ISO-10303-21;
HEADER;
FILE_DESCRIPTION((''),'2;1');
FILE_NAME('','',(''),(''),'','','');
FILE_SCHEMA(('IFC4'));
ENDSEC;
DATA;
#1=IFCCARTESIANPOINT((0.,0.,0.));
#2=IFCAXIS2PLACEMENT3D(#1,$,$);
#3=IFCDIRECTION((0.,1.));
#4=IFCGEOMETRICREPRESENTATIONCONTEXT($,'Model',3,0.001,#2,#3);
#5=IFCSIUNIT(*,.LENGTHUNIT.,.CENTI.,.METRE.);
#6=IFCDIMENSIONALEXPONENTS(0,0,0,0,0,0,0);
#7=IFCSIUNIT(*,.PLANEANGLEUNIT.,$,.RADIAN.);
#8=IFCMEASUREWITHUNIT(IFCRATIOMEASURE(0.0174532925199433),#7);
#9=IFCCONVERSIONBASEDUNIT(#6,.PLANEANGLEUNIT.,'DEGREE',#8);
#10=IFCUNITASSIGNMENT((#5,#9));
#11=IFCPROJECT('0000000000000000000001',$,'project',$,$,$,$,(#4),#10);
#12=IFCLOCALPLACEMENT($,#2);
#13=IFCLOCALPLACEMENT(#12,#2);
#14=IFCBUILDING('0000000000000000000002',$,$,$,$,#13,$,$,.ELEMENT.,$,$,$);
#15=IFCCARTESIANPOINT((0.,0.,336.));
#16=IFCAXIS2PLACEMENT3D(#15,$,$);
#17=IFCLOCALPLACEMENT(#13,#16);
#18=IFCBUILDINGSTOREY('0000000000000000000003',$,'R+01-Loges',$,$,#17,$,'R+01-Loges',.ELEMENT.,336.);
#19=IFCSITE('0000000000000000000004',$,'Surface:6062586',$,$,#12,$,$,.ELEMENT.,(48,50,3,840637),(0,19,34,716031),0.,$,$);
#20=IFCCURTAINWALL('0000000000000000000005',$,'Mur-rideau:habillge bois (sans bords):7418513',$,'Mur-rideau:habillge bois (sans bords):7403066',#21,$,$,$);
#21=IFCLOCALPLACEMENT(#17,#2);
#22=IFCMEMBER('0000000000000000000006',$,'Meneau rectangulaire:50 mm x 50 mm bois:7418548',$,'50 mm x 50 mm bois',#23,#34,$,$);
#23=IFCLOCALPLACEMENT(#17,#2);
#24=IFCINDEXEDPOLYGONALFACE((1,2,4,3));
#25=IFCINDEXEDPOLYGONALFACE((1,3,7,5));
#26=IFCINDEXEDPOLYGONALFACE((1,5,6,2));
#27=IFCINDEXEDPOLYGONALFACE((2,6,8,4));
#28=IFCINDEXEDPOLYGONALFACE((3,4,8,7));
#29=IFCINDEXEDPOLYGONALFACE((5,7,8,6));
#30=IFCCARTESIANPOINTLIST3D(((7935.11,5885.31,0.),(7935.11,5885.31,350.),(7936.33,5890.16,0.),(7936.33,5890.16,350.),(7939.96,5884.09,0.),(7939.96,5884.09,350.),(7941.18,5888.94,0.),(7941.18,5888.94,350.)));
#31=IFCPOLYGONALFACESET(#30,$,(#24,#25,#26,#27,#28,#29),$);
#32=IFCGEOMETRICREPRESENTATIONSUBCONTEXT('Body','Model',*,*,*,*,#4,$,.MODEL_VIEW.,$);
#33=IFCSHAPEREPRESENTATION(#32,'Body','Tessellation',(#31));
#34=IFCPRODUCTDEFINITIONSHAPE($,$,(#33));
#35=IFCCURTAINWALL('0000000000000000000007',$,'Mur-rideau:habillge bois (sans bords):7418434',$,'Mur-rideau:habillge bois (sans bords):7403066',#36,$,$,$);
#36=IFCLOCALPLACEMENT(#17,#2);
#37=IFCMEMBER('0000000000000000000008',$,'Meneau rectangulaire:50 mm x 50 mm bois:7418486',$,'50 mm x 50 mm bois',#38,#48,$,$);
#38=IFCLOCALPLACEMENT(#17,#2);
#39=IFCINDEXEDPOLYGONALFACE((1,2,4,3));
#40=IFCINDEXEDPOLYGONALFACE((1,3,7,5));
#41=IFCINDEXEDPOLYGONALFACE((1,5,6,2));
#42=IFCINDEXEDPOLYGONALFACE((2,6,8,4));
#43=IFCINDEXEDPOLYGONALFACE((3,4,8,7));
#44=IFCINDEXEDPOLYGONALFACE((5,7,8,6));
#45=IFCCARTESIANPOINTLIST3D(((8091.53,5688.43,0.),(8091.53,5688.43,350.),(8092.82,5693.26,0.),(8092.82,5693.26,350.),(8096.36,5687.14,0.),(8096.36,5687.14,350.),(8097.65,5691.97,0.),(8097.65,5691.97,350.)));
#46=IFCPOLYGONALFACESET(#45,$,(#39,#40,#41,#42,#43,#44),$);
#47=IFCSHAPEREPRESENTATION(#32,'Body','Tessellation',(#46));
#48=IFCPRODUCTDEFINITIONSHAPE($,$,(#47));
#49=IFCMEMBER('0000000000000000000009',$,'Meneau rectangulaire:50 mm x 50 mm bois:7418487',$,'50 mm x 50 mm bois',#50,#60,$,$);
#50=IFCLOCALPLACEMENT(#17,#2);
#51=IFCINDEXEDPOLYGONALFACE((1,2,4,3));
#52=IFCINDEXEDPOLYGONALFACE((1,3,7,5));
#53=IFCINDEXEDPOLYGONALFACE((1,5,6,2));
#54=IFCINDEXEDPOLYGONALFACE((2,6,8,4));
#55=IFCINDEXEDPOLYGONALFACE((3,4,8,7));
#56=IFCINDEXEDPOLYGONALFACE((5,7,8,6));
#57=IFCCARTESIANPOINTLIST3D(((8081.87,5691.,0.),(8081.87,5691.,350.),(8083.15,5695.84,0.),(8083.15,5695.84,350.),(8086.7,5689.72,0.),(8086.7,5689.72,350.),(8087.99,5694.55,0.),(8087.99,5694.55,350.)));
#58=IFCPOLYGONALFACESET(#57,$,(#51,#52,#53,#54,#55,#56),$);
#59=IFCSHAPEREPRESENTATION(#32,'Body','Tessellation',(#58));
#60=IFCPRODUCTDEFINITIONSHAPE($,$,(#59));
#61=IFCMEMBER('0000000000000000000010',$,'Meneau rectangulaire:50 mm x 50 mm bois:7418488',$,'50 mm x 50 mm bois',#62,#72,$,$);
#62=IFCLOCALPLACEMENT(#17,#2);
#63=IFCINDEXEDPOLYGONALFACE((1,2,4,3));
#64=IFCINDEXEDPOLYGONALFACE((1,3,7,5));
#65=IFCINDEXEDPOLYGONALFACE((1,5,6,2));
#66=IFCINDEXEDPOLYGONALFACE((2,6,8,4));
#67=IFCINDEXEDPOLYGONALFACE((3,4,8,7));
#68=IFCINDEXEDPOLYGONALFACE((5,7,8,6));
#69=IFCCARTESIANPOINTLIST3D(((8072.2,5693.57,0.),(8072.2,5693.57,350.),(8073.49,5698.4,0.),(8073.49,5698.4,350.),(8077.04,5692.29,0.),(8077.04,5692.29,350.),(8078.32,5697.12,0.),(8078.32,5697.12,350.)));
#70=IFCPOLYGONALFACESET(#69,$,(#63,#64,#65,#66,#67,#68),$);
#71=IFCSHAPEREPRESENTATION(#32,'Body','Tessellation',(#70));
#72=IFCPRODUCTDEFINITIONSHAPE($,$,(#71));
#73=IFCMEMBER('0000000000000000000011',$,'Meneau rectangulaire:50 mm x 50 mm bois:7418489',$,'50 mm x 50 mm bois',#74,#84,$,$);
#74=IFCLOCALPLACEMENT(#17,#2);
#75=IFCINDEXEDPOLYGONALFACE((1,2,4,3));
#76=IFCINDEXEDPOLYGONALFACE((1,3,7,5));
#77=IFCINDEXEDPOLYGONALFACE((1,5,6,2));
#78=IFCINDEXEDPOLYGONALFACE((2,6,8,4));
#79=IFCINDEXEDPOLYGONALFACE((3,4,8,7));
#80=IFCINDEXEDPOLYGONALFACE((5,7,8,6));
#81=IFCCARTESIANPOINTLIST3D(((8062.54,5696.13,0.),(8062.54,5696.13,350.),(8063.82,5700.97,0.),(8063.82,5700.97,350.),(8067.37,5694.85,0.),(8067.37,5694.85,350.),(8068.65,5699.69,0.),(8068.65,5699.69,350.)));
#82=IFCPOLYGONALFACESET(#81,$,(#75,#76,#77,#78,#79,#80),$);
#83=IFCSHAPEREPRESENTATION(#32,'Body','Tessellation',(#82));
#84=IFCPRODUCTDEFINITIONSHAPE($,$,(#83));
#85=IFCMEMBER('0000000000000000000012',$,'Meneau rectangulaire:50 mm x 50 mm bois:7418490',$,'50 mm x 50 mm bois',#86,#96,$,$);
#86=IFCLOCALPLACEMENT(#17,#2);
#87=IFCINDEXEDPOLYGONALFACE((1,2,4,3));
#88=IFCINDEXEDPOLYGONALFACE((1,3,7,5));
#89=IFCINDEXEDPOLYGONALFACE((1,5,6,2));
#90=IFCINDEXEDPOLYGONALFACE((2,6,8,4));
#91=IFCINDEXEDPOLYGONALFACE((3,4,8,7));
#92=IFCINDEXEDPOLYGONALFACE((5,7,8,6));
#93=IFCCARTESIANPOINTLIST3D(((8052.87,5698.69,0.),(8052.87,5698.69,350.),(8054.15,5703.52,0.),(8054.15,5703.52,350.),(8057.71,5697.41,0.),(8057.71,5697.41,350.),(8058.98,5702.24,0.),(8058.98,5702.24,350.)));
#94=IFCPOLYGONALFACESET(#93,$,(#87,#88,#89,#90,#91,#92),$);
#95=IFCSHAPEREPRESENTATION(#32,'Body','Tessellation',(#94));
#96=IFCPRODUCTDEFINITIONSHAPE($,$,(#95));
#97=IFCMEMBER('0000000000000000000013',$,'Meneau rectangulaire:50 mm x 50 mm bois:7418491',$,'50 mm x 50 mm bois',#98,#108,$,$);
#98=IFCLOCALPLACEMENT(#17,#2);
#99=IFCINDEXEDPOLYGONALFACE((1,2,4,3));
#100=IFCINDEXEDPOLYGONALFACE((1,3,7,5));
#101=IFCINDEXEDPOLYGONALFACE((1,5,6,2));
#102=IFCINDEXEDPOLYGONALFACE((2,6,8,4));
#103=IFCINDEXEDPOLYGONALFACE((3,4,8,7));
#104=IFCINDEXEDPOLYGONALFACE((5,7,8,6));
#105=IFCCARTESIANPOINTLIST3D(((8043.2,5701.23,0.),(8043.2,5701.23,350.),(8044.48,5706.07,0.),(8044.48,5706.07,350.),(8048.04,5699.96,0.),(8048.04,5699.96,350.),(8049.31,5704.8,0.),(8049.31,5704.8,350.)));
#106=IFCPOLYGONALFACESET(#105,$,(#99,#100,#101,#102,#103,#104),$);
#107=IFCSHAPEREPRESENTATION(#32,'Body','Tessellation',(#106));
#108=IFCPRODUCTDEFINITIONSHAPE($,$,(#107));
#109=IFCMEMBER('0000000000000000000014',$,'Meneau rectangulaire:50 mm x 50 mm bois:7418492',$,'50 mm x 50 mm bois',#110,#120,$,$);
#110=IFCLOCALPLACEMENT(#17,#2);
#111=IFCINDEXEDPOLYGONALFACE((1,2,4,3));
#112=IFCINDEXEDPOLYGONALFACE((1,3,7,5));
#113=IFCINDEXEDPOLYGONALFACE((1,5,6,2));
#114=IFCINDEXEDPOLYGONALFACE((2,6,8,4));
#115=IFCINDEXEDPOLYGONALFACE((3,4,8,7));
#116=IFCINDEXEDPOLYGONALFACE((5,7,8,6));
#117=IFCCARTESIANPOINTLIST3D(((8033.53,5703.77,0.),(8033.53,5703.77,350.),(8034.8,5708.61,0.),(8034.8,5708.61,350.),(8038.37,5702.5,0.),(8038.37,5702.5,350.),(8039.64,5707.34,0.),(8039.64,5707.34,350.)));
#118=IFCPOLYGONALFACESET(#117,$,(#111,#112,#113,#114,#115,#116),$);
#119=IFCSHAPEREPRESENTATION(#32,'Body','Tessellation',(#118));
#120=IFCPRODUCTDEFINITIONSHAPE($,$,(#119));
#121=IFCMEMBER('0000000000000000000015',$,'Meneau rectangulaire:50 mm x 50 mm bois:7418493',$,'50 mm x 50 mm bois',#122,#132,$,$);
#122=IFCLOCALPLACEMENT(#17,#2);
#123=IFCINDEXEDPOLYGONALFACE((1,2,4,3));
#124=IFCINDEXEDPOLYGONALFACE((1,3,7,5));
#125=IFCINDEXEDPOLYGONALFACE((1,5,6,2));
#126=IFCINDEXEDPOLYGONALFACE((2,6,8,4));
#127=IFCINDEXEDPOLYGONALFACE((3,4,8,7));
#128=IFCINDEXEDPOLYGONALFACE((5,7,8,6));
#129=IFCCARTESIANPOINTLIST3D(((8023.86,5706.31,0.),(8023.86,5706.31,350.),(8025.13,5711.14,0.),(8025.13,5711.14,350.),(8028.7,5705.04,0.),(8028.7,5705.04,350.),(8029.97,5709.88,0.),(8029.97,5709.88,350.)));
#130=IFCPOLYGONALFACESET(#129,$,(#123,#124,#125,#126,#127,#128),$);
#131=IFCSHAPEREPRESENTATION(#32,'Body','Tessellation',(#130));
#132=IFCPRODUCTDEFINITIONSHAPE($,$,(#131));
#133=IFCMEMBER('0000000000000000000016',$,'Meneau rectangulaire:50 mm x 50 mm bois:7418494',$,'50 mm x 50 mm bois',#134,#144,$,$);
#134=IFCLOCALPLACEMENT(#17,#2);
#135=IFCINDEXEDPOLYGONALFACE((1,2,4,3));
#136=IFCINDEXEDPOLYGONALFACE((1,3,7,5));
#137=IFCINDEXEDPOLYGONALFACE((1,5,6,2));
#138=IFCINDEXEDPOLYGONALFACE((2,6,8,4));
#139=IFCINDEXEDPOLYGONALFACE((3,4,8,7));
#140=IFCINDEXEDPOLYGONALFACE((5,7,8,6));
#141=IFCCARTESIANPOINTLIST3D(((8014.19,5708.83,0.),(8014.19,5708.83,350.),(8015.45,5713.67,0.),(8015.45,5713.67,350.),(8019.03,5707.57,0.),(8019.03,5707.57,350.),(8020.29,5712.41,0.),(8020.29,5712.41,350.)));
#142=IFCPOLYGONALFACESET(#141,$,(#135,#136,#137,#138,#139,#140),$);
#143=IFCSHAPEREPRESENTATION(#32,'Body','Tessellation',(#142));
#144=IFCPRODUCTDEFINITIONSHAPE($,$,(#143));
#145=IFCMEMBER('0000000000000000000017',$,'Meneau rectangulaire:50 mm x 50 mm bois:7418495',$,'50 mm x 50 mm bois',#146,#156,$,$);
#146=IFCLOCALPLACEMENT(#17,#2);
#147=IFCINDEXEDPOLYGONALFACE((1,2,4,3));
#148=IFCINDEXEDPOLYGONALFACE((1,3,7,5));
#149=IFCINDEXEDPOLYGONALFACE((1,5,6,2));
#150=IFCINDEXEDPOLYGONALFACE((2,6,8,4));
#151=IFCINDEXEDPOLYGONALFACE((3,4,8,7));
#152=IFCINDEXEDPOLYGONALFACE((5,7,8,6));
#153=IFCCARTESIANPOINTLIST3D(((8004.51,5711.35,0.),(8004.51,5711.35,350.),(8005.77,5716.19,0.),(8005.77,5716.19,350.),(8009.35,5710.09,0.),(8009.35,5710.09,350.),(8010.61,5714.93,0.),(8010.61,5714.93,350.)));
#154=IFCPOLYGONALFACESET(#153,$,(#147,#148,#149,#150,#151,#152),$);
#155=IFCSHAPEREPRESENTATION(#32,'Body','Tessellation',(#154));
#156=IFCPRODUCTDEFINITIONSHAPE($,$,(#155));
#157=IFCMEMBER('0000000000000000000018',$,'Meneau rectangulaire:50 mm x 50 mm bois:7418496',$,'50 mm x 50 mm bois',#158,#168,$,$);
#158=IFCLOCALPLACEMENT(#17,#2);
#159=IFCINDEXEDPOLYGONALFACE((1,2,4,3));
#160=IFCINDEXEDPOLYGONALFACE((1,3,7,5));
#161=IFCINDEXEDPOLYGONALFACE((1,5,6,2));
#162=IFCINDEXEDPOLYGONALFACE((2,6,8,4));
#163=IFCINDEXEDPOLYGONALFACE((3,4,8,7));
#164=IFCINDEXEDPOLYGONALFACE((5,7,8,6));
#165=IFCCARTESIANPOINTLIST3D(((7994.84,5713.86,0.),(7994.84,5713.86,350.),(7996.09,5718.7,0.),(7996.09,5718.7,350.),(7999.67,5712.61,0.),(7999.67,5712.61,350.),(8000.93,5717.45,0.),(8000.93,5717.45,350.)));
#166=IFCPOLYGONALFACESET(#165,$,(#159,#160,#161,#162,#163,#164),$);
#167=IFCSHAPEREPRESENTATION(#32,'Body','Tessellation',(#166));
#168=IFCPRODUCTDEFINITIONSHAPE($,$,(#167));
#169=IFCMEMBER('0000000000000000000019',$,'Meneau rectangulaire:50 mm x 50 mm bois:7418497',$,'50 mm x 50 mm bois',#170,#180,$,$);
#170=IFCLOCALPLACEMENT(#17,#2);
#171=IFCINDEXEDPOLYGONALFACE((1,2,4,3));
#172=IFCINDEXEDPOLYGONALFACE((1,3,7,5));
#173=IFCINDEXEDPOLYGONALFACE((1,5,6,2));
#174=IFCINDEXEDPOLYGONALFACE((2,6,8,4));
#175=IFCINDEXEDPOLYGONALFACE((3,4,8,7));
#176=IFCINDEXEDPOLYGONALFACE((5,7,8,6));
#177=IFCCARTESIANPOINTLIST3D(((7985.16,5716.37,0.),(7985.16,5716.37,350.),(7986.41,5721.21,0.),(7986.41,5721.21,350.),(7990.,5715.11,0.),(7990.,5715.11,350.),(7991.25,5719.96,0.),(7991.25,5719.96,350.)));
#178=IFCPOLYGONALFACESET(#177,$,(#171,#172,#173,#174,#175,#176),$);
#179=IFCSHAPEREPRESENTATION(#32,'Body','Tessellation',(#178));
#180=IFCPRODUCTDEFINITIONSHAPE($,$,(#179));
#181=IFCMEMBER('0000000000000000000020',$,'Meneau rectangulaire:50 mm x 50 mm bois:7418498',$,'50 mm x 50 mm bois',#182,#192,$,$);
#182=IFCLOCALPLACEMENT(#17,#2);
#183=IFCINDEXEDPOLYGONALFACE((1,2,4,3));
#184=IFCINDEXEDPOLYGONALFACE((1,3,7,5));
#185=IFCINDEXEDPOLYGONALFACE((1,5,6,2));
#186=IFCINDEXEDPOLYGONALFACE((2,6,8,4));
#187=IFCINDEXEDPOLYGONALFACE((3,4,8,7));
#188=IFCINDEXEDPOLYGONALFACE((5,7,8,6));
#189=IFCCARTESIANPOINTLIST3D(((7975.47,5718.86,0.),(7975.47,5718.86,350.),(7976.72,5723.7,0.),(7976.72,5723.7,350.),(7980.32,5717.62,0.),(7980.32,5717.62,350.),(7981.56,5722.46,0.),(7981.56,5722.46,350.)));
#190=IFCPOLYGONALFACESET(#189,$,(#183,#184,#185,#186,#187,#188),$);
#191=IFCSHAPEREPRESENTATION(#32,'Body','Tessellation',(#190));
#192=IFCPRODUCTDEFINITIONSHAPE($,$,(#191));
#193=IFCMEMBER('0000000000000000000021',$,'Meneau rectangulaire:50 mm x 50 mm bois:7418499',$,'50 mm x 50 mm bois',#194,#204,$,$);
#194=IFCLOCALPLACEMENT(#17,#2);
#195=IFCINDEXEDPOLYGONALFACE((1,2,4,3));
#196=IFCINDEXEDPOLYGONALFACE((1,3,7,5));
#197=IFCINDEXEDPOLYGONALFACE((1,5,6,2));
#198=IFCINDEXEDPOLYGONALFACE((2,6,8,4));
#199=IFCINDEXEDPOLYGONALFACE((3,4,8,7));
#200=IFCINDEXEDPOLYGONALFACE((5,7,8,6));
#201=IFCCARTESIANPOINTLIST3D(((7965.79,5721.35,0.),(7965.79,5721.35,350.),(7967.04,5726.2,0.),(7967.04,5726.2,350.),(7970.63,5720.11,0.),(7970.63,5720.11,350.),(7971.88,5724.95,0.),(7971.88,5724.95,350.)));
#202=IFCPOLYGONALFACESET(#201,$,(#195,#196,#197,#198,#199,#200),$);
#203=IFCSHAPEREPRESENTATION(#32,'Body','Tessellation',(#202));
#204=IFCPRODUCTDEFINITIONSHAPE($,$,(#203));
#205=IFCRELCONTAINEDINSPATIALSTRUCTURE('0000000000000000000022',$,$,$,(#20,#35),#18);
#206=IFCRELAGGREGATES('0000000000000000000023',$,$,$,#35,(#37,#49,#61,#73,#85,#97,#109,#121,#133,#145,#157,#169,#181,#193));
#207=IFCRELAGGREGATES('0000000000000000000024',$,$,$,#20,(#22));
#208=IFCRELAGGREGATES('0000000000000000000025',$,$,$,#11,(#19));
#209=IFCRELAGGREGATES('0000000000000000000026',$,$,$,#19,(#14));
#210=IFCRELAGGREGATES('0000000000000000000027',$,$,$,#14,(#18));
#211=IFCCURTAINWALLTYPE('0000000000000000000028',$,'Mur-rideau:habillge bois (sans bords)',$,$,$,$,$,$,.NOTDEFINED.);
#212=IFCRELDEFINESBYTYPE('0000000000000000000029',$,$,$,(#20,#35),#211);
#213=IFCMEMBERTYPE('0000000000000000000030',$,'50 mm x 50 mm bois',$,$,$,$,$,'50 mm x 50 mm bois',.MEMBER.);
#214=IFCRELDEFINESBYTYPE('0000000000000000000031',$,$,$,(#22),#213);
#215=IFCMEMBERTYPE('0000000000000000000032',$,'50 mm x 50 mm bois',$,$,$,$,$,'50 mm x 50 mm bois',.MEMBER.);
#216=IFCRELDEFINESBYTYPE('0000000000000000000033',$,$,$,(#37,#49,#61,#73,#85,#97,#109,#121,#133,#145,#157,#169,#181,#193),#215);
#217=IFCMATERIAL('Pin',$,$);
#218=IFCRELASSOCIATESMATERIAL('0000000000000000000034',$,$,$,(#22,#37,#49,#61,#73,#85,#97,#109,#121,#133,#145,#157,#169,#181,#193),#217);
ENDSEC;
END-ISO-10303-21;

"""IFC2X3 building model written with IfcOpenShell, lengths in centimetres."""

from ifc_helpers import new_model, entity, si_unit, converted_unit, direction, frame, origin, origin_2d_with_axis, place, context, subcontext, project, spatial, rectangle, extrude, source, transform, mapped, material, type_object, type_shapes, element, aggregate, save


model = new_model("IFC2X3")

# Units and contexts
model_context = context("Model", 3, precision=0.001, world=origin(), true_north=direction((0.0, 1.0)))
body_context = subcontext(model_context, "Body", "Model", "MODEL_VIEW")
ifc_project = project(units=[si_unit("LENGTHUNIT", "METRE", prefix="CENTI"), converted_unit("PLANEANGLEUNIT", "DEGREE", entity("IfcRatioMeasure", 0.0174532925199433), si_unit("PLANEANGLEUNIT", "RADIAN"), dimensions=[0, 0, 0, 0, 0, 0, 0])], contexts=[model_context])

# Site, building, storey
site_placement = place(None, origin())
site = spatial("IfcSite", under=ifc_project, at=site_placement, Name="Surface:6062586", CompositionType="ELEMENT", RefLatitude=(48, 50, 3, 840637), RefLongitude=(0, 19, 34, 716031), RefElevation=0.0)
building_placement = place(site_placement, origin())
building = spatial("IfcBuilding", under=site, at=building_placement, CompositionType="ELEMENT")
storey_placement = place(building_placement, frame((0.0, 0.0, 336.0)))
storey = spatial("IfcBuildingStorey", under=building, at=storey_placement, Name="R+01-Loges", LongName="R+01-Loges", CompositionType="ELEMENT", Elevation=336.0)

# Curtain wall, member
curtain_wall_type = type_object("IfcCurtainWallType", Name="Mur-rideau:habillge bois (sans bords)", PredefinedType="NOTDEFINED")
curtain_wall_1_placement = place(storey_placement, frame((0.0, 0.0, -336.0)))
curtain_wall_1 = element("IfcCurtainWall", 1, at=curtain_wall_1_placement, inside=storey, type_object=curtain_wall_type, Name="Mur-rideau:habillge bois (sans bords):7418513", ObjectType="Mur-rideau:habillge bois (sans bords):7403066")
ifc_material = material(Name="Pin")
member_type_1 = type_object("IfcMemberType", Name="50 mm x 50 mm bois", ElementType="50 mm x 50 mm bois", PredefinedType="MEMBER")
shared_shape_1 = source(origin(), body_context, "Body", "SweptSolid", [
    extrude(rectangle(XDim=5.0, YDim=5.0, at=origin_2d_with_axis()), frame((-2.5, 0.0, -350.0), z_axis=(0.0, 0.0, 1.0), x_axis=(0.0, -1.0, 0.0)), (0.0, 0.0, 1.0), 350.0),
])
type_shapes(member_type_1, [shared_shape_1])
member_1_placement = place(storey_placement, frame((7938.75, 5889.55, 0.0), z_axis=(0.0, 0.0, -1.0), x_axis=(0.244071, 0.969757, 0.0)))
member_1 = element("IfcMember", 2, at=member_1_placement, type_object=member_type_1, material=ifc_material, Name="Meneau rectangulaire:50 mm x 50 mm bois:7418548", ObjectType="50 mm x 50 mm bois", context=body_context, shape_type="MappedRepresentation", body=[
    mapped(shared_shape_1, transform((0.0, 0.0, 0.0), scale=1.0)),
])

# Curtain wall, members
curtain_wall_2_placement = place(storey_placement, frame((0.0, 0.0, -336.0)))
curtain_wall_2 = element("IfcCurtainWall", 3, at=curtain_wall_2_placement, inside=storey, type_object=curtain_wall_type, Name="Mur-rideau:habillge bois (sans bords):7418434", ObjectType="Mur-rideau:habillge bois (sans bords):7403066")
member_type_2 = type_object("IfcMemberType", Name="50 mm x 50 mm bois", ElementType="50 mm x 50 mm bois", PredefinedType="MEMBER")
shared_shape_2 = source(origin(), body_context, "Body", "SweptSolid", [
    extrude(rectangle(XDim=5.0, YDim=5.0, at=origin_2d_with_axis()), frame((0.0, 0.0, -350.0), z_axis=(0.0, 0.0, 1.0), x_axis=(0.0, -1.0, 0.0)), (0.0, 0.0, 1.0), 350.0),
])
type_shapes(member_type_2, [shared_shape_2])
member_2_placement = place(storey_placement, frame((8094.59, 5690.2, 0.0), z_axis=(0.0, 0.0, -1.0), x_axis=(-0.966113, 0.258119, 0.0)))
member_2 = element("IfcMember", 4, at=member_2_placement, type_object=member_type_2, material=ifc_material, Name="Meneau rectangulaire:50 mm x 50 mm bois:7418486", ObjectType="50 mm x 50 mm bois", context=body_context, shape_type="MappedRepresentation", body=[
    mapped(shared_shape_2, transform((0.0, 0.0, 0.0), scale=1.0)),
])
member_3_placement = place(storey_placement, frame((8084.93, 5692.78, 0.0), z_axis=(0.0, 0.0, -1.0), x_axis=(-0.966303, 0.257408, 0.0)))
member_3 = element("IfcMember", 5, at=member_3_placement, type_object=member_type_2, material=ifc_material, Name="Meneau rectangulaire:50 mm x 50 mm bois:7418487", ObjectType="50 mm x 50 mm bois", context=body_context, shape_type="MappedRepresentation", body=[
    mapped(shared_shape_2, transform((0.0, 0.0, 0.0), scale=1.0)),
])
member_4_placement = place(storey_placement, frame((8075.26, 5695.35, 0.0), z_axis=(0.0, 0.0, -1.0), x_axis=(-0.966492, 0.256697, 0.0)))
member_4 = element("IfcMember", 6, at=member_4_placement, type_object=member_type_2, material=ifc_material, Name="Meneau rectangulaire:50 mm x 50 mm bois:7418488", ObjectType="50 mm x 50 mm bois", context=body_context, shape_type="MappedRepresentation", body=[
    mapped(shared_shape_2, transform((0.0, 0.0, 0.0), scale=1.0)),
])
member_5_placement = place(storey_placement, frame((8065.6, 5697.91, 0.0), z_axis=(0.0, 0.0, -1.0), x_axis=(-0.966681, 0.255985, 0.0)))
member_5 = element("IfcMember", 7, at=member_5_placement, type_object=member_type_2, material=ifc_material, Name="Meneau rectangulaire:50 mm x 50 mm bois:7418489", ObjectType="50 mm x 50 mm bois", context=body_context, shape_type="MappedRepresentation", body=[
    mapped(shared_shape_2, transform((0.0, 0.0, 0.0), scale=1.0)),
])
member_6_placement = place(storey_placement, frame((8055.93, 5700.47, 0.0), z_axis=(0.0, 0.0, -1.0), x_axis=(-0.966869, 0.255274, 0.0)))
member_6 = element("IfcMember", 8, at=member_6_placement, type_object=member_type_2, material=ifc_material, Name="Meneau rectangulaire:50 mm x 50 mm bois:7418490", ObjectType="50 mm x 50 mm bois", context=body_context, shape_type="MappedRepresentation", body=[
    mapped(shared_shape_2, transform((0.0, 0.0, 0.0), scale=1.0)),
])
member_7_placement = place(storey_placement, frame((8046.26, 5703.02, 0.0), z_axis=(0.0, 0.0, -1.0), x_axis=(-0.967056, 0.254562, 0.0)))
member_7 = element("IfcMember", 9, at=member_7_placement, type_object=member_type_2, material=ifc_material, Name="Meneau rectangulaire:50 mm x 50 mm bois:7418491", ObjectType="50 mm x 50 mm bois", context=body_context, shape_type="MappedRepresentation", body=[
    mapped(shared_shape_2, transform((0.0, 0.0, 0.0), scale=1.0)),
])
member_8_placement = place(storey_placement, frame((8036.59, 5705.56, 0.0), z_axis=(0.0, 0.0, -1.0), x_axis=(-0.967244, 0.25385, 0.0)))
member_8 = element("IfcMember", 10, at=member_8_placement, type_object=member_type_2, material=ifc_material, Name="Meneau rectangulaire:50 mm x 50 mm bois:7418492", ObjectType="50 mm x 50 mm bois", context=body_context, shape_type="MappedRepresentation", body=[
    mapped(shared_shape_2, transform((0.0, 0.0, 0.0), scale=1.0)),
])
member_9_placement = place(storey_placement, frame((8026.91, 5708.09, 0.0), z_axis=(0.0, 0.0, -1.0), x_axis=(-0.96743, 0.253138, 0.0)))
member_9 = element("IfcMember", 11, at=member_9_placement, type_object=member_type_2, material=ifc_material, Name="Meneau rectangulaire:50 mm x 50 mm bois:7418493", ObjectType="50 mm x 50 mm bois", context=body_context, shape_type="MappedRepresentation", body=[
    mapped(shared_shape_2, transform((0.0, 0.0, 0.0), scale=1.0)),
])
member_10_placement = place(storey_placement, frame((8017.24, 5710.62, 0.0), z_axis=(0.0, 0.0, -1.0), x_axis=(-0.967616, 0.252426, 0.0)))
member_10 = element("IfcMember", 12, at=member_10_placement, type_object=member_type_2, material=ifc_material, Name="Meneau rectangulaire:50 mm x 50 mm bois:7418494", ObjectType="50 mm x 50 mm bois", context=body_context, shape_type="MappedRepresentation", body=[
    mapped(shared_shape_2, transform((0.0, 0.0, 0.0), scale=1.0)),
])
member_11_placement = place(storey_placement, frame((8007.56, 5713.14, 0.0), z_axis=(0.0, 0.0, -1.0), x_axis=(-0.967802, 0.251714, 0.0)))
member_11 = element("IfcMember", 13, at=member_11_placement, type_object=member_type_2, material=ifc_material, Name="Meneau rectangulaire:50 mm x 50 mm bois:7418495", ObjectType="50 mm x 50 mm bois", context=body_context, shape_type="MappedRepresentation", body=[
    mapped(shared_shape_2, transform((0.0, 0.0, 0.0), scale=1.0)),
])
member_12_placement = place(storey_placement, frame((7997.88, 5715.65, 0.0), z_axis=(0.0, 0.0, -1.0), x_axis=(-0.967987, 0.251002, 0.0)))
member_12 = element("IfcMember", 14, at=member_12_placement, type_object=member_type_2, material=ifc_material, Name="Meneau rectangulaire:50 mm x 50 mm bois:7418496", ObjectType="50 mm x 50 mm bois", context=body_context, shape_type="MappedRepresentation", body=[
    mapped(shared_shape_2, transform((0.0, 0.0, 0.0), scale=1.0)),
])
member_13_placement = place(storey_placement, frame((7988.2, 5718.16, 0.0), z_axis=(0.0, 0.0, -1.0), x_axis=(-0.968171, 0.250289, 0.0)))
member_13 = element("IfcMember", 15, at=member_13_placement, type_object=member_type_2, material=ifc_material, Name="Meneau rectangulaire:50 mm x 50 mm bois:7418497", ObjectType="50 mm x 50 mm bois", context=body_context, shape_type="MappedRepresentation", body=[
    mapped(shared_shape_2, transform((0.0, 0.0, 0.0), scale=1.0)),
])
member_14_placement = place(storey_placement, frame((7978.52, 5720.66, 0.0), z_axis=(0.0, 0.0, -1.0), x_axis=(-0.968355, 0.249577, 0.0)))
member_14 = element("IfcMember", 16, at=member_14_placement, type_object=member_type_2, material=ifc_material, Name="Meneau rectangulaire:50 mm x 50 mm bois:7418498", ObjectType="50 mm x 50 mm bois", context=body_context, shape_type="MappedRepresentation", body=[
    mapped(shared_shape_2, transform((0.0, 0.0, 0.0), scale=1.0)),
])
member_15_placement = place(storey_placement, frame((7968.83, 5723.15, 0.0), z_axis=(0.0, 0.0, -1.0), x_axis=(-0.968538, 0.248864, 0.0)))
member_15 = element("IfcMember", 17, at=member_15_placement, type_object=member_type_2, material=ifc_material, Name="Meneau rectangulaire:50 mm x 50 mm bois:7418499", ObjectType="50 mm x 50 mm bois", context=body_context, shape_type="MappedRepresentation", body=[
    mapped(shared_shape_2, transform((0.0, 0.0, 0.0), scale=1.0)),
])
aggregate(curtain_wall_2, [member_2, member_3, member_4, member_5, member_6, member_7, member_8, member_9, member_10, member_11, member_12, member_13, member_14, member_15])

aggregate(curtain_wall_1, [member_1])

save(model, "model.ifc")
